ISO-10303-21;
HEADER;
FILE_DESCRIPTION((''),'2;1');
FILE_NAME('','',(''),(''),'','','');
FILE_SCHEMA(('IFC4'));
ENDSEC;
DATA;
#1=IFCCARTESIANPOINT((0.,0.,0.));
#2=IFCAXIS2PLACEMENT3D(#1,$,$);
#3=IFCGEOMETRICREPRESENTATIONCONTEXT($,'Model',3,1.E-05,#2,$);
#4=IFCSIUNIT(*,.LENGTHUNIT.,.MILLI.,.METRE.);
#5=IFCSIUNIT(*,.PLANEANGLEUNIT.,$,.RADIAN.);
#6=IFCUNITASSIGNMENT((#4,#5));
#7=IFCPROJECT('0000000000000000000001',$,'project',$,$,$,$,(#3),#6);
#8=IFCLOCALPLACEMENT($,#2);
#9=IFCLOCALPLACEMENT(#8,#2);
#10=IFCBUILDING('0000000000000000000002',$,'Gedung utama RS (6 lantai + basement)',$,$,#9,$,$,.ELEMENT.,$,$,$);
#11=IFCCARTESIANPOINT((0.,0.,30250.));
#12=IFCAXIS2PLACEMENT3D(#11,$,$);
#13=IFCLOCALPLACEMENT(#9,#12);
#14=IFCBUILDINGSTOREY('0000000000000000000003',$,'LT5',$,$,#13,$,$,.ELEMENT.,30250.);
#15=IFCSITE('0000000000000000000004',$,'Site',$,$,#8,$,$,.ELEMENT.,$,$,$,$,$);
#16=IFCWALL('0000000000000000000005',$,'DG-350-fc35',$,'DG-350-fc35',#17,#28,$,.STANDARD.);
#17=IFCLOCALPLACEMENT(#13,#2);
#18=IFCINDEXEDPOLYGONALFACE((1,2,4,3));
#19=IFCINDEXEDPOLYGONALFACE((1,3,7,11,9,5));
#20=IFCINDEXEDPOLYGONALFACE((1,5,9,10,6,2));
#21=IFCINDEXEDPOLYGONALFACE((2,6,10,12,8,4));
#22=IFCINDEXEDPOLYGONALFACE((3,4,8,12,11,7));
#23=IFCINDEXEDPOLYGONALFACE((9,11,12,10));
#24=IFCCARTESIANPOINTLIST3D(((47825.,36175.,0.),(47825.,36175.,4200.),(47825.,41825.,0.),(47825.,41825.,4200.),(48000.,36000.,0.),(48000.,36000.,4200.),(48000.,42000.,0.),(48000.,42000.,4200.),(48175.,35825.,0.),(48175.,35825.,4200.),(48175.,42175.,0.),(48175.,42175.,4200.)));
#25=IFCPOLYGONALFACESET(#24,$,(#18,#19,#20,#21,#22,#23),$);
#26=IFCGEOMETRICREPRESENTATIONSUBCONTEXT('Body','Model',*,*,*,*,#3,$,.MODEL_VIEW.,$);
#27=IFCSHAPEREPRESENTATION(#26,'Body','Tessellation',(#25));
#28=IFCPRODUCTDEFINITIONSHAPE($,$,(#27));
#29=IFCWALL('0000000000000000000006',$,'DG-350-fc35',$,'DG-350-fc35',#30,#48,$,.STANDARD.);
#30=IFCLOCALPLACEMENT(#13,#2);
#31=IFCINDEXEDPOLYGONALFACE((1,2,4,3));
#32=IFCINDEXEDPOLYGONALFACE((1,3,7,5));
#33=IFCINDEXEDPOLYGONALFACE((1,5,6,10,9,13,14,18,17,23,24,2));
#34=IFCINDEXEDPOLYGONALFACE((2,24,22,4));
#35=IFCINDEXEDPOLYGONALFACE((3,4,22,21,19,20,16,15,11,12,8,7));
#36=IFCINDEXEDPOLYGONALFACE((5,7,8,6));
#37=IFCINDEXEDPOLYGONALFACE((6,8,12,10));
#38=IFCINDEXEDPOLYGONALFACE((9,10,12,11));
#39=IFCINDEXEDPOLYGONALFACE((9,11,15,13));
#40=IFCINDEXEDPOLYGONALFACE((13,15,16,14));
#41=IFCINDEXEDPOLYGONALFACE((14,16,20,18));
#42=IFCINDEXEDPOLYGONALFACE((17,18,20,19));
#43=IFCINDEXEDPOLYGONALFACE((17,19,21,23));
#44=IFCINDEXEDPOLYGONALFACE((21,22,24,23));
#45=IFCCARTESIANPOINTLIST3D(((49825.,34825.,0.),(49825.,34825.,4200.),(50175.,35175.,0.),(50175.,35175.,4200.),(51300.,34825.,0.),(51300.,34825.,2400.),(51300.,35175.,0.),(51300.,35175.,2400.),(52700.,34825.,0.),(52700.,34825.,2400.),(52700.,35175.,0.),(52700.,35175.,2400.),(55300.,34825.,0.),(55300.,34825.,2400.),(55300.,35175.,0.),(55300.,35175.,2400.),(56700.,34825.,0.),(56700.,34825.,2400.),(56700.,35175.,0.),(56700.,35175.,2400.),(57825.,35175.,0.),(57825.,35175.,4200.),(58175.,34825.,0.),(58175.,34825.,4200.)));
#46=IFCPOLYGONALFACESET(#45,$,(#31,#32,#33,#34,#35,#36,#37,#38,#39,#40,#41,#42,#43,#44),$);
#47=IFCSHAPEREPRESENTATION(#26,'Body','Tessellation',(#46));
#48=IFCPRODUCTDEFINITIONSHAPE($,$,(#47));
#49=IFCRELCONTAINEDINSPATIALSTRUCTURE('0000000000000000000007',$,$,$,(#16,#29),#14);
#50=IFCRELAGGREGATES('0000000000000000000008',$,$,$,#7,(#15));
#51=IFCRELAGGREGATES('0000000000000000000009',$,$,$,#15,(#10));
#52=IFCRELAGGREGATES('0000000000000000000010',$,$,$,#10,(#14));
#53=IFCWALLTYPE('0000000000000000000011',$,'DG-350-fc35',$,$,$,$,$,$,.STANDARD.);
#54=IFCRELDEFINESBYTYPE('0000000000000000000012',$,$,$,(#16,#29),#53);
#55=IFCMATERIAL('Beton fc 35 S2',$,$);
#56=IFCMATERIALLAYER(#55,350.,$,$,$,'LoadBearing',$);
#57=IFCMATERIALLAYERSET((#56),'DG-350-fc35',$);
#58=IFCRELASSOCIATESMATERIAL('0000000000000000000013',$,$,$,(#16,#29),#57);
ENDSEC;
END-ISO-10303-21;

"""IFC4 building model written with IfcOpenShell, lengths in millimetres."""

from ifc_helpers import new_model, si_unit, frame, frame_2d, origin, place, context, subcontext, project, spatial, polyline, rectangle, outline, extrude, material, layer, layer_set, layer_usage, type_object, element, save


model = new_model("IFC4")

# Units and contexts
model_context = context("Model", 3, precision=1e-05, world=origin())
body_context = subcontext(model_context, "Body", "Model", "MODEL_VIEW")
ifc_project = project(units=[si_unit("LENGTHUNIT", "METRE", prefix="MILLI"), si_unit("PLANEANGLEUNIT", "RADIAN")], contexts=[model_context])

# Site, building, storey
site_placement = place(None, origin())
site = spatial("IfcSite", under=ifc_project, at=site_placement, Name="Site", CompositionType="ELEMENT")
building_placement = place(site_placement, origin())
building = spatial("IfcBuilding", under=site, at=building_placement, Name="Gedung utama RS (6 lantai + basement)", CompositionType="ELEMENT")
storey_placement = place(building_placement, frame((0.0, 0.0, 30250.0)))
storey = spatial("IfcBuildingStorey", under=building, at=storey_placement, Name="LT5", CompositionType="ELEMENT", Elevation=30250.0)

# Shared definitions
ifc_material_1 = material(Name="Beton fc 35 S2")
ifc_layer_1 = layer(ifc_material_1, 350.0, Category="LoadBearing")
ifc_layer_set_1 = layer_set([ifc_layer_1], Name="DG-350-fc35")
ifc_layer_usage_1 = layer_usage(ifc_layer_set_1, "AXIS2", "NEGATIVE", 175.0)
wall_type_1 = type_object("IfcWallType", Name="DG-350-fc35", PredefinedType="STANDARD")

# Wall
wall_1_placement = place(storey_placement, frame((48000.0, 36000.0, 0.0), z_axis=(0.0, 0.0, 1.0), x_axis=(0.0, 1.0, 0.0)))
element("IfcWall", 1, at=wall_1_placement, inside=storey, type_object=wall_type_1, material=ifc_layer_usage_1, Name="DG-350-fc35", ObjectType="DG-350-fc35", PredefinedType="STANDARD", context=body_context, shape_type="SweptSolid", body=[
    extrude(outline(polyline([(-175.0, -175.0), (0.0, 0.0), (175.0, 175.0), (5825.0, 175.0), (6000.0, 0.0), (6175.0, -175.0), (-175.0, -175.0)])), origin(), (0.0, 0.0, 1.0), 4200.0),
])

# Wall, openings
wall_2_placement = place(storey_placement, frame((50000.0, 35000.0, 0.0), z_axis=(0.0, 0.0, 1.0), x_axis=(1.0, 0.0, 0.0)))
wall_2 = element("IfcWall", 2, at=wall_2_placement, inside=storey, type_object=wall_type_1, material=ifc_layer_usage_1, Name="DG-350-fc35", ObjectType="DG-350-fc35", PredefinedType="STANDARD", context=body_context, shape_type="SweptSolid", body=[
    extrude(outline(polyline([(-175.0, -175.0), (0.0, 0.0), (175.0, 175.0), (7825.0, 175.0), (8000.0, 0.0), (8175.0, -175.0), (-175.0, -175.0)])), origin(), (0.0, 0.0, 1.0), 4200.0),
])
opening_1_placement = place(wall_2_placement, frame((1300.0, 0.0, 0.0), z_axis=(0.0, 0.0, 1.0), x_axis=(1.0, 0.0, 0.0)))
element("IfcOpeningElement", 3, at=opening_1_placement, cuts=wall_2, PredefinedType="OPENING", context=body_context, shape_type="SweptSolid", body=[
    extrude(rectangle(XDim=1400.0, YDim=370.0, at=frame_2d((700.0, 0.0))), origin(), (0.0, 0.0, 1.0), 2400.0),
])
opening_2_placement = place(wall_2_placement, frame((5300.0, 0.0, 0.0), z_axis=(0.0, 0.0, 1.0), x_axis=(1.0, 0.0, 0.0)))
element("IfcOpeningElement", 4, at=opening_2_placement, cuts=wall_2, PredefinedType="OPENING", context=body_context, shape_type="SweptSolid", body=[
    extrude(rectangle(XDim=1400.0, YDim=370.0, at=frame_2d((700.0, 0.0))), origin(), (0.0, 0.0, 1.0), 2400.0),
])

save(model, "model.ifc")
